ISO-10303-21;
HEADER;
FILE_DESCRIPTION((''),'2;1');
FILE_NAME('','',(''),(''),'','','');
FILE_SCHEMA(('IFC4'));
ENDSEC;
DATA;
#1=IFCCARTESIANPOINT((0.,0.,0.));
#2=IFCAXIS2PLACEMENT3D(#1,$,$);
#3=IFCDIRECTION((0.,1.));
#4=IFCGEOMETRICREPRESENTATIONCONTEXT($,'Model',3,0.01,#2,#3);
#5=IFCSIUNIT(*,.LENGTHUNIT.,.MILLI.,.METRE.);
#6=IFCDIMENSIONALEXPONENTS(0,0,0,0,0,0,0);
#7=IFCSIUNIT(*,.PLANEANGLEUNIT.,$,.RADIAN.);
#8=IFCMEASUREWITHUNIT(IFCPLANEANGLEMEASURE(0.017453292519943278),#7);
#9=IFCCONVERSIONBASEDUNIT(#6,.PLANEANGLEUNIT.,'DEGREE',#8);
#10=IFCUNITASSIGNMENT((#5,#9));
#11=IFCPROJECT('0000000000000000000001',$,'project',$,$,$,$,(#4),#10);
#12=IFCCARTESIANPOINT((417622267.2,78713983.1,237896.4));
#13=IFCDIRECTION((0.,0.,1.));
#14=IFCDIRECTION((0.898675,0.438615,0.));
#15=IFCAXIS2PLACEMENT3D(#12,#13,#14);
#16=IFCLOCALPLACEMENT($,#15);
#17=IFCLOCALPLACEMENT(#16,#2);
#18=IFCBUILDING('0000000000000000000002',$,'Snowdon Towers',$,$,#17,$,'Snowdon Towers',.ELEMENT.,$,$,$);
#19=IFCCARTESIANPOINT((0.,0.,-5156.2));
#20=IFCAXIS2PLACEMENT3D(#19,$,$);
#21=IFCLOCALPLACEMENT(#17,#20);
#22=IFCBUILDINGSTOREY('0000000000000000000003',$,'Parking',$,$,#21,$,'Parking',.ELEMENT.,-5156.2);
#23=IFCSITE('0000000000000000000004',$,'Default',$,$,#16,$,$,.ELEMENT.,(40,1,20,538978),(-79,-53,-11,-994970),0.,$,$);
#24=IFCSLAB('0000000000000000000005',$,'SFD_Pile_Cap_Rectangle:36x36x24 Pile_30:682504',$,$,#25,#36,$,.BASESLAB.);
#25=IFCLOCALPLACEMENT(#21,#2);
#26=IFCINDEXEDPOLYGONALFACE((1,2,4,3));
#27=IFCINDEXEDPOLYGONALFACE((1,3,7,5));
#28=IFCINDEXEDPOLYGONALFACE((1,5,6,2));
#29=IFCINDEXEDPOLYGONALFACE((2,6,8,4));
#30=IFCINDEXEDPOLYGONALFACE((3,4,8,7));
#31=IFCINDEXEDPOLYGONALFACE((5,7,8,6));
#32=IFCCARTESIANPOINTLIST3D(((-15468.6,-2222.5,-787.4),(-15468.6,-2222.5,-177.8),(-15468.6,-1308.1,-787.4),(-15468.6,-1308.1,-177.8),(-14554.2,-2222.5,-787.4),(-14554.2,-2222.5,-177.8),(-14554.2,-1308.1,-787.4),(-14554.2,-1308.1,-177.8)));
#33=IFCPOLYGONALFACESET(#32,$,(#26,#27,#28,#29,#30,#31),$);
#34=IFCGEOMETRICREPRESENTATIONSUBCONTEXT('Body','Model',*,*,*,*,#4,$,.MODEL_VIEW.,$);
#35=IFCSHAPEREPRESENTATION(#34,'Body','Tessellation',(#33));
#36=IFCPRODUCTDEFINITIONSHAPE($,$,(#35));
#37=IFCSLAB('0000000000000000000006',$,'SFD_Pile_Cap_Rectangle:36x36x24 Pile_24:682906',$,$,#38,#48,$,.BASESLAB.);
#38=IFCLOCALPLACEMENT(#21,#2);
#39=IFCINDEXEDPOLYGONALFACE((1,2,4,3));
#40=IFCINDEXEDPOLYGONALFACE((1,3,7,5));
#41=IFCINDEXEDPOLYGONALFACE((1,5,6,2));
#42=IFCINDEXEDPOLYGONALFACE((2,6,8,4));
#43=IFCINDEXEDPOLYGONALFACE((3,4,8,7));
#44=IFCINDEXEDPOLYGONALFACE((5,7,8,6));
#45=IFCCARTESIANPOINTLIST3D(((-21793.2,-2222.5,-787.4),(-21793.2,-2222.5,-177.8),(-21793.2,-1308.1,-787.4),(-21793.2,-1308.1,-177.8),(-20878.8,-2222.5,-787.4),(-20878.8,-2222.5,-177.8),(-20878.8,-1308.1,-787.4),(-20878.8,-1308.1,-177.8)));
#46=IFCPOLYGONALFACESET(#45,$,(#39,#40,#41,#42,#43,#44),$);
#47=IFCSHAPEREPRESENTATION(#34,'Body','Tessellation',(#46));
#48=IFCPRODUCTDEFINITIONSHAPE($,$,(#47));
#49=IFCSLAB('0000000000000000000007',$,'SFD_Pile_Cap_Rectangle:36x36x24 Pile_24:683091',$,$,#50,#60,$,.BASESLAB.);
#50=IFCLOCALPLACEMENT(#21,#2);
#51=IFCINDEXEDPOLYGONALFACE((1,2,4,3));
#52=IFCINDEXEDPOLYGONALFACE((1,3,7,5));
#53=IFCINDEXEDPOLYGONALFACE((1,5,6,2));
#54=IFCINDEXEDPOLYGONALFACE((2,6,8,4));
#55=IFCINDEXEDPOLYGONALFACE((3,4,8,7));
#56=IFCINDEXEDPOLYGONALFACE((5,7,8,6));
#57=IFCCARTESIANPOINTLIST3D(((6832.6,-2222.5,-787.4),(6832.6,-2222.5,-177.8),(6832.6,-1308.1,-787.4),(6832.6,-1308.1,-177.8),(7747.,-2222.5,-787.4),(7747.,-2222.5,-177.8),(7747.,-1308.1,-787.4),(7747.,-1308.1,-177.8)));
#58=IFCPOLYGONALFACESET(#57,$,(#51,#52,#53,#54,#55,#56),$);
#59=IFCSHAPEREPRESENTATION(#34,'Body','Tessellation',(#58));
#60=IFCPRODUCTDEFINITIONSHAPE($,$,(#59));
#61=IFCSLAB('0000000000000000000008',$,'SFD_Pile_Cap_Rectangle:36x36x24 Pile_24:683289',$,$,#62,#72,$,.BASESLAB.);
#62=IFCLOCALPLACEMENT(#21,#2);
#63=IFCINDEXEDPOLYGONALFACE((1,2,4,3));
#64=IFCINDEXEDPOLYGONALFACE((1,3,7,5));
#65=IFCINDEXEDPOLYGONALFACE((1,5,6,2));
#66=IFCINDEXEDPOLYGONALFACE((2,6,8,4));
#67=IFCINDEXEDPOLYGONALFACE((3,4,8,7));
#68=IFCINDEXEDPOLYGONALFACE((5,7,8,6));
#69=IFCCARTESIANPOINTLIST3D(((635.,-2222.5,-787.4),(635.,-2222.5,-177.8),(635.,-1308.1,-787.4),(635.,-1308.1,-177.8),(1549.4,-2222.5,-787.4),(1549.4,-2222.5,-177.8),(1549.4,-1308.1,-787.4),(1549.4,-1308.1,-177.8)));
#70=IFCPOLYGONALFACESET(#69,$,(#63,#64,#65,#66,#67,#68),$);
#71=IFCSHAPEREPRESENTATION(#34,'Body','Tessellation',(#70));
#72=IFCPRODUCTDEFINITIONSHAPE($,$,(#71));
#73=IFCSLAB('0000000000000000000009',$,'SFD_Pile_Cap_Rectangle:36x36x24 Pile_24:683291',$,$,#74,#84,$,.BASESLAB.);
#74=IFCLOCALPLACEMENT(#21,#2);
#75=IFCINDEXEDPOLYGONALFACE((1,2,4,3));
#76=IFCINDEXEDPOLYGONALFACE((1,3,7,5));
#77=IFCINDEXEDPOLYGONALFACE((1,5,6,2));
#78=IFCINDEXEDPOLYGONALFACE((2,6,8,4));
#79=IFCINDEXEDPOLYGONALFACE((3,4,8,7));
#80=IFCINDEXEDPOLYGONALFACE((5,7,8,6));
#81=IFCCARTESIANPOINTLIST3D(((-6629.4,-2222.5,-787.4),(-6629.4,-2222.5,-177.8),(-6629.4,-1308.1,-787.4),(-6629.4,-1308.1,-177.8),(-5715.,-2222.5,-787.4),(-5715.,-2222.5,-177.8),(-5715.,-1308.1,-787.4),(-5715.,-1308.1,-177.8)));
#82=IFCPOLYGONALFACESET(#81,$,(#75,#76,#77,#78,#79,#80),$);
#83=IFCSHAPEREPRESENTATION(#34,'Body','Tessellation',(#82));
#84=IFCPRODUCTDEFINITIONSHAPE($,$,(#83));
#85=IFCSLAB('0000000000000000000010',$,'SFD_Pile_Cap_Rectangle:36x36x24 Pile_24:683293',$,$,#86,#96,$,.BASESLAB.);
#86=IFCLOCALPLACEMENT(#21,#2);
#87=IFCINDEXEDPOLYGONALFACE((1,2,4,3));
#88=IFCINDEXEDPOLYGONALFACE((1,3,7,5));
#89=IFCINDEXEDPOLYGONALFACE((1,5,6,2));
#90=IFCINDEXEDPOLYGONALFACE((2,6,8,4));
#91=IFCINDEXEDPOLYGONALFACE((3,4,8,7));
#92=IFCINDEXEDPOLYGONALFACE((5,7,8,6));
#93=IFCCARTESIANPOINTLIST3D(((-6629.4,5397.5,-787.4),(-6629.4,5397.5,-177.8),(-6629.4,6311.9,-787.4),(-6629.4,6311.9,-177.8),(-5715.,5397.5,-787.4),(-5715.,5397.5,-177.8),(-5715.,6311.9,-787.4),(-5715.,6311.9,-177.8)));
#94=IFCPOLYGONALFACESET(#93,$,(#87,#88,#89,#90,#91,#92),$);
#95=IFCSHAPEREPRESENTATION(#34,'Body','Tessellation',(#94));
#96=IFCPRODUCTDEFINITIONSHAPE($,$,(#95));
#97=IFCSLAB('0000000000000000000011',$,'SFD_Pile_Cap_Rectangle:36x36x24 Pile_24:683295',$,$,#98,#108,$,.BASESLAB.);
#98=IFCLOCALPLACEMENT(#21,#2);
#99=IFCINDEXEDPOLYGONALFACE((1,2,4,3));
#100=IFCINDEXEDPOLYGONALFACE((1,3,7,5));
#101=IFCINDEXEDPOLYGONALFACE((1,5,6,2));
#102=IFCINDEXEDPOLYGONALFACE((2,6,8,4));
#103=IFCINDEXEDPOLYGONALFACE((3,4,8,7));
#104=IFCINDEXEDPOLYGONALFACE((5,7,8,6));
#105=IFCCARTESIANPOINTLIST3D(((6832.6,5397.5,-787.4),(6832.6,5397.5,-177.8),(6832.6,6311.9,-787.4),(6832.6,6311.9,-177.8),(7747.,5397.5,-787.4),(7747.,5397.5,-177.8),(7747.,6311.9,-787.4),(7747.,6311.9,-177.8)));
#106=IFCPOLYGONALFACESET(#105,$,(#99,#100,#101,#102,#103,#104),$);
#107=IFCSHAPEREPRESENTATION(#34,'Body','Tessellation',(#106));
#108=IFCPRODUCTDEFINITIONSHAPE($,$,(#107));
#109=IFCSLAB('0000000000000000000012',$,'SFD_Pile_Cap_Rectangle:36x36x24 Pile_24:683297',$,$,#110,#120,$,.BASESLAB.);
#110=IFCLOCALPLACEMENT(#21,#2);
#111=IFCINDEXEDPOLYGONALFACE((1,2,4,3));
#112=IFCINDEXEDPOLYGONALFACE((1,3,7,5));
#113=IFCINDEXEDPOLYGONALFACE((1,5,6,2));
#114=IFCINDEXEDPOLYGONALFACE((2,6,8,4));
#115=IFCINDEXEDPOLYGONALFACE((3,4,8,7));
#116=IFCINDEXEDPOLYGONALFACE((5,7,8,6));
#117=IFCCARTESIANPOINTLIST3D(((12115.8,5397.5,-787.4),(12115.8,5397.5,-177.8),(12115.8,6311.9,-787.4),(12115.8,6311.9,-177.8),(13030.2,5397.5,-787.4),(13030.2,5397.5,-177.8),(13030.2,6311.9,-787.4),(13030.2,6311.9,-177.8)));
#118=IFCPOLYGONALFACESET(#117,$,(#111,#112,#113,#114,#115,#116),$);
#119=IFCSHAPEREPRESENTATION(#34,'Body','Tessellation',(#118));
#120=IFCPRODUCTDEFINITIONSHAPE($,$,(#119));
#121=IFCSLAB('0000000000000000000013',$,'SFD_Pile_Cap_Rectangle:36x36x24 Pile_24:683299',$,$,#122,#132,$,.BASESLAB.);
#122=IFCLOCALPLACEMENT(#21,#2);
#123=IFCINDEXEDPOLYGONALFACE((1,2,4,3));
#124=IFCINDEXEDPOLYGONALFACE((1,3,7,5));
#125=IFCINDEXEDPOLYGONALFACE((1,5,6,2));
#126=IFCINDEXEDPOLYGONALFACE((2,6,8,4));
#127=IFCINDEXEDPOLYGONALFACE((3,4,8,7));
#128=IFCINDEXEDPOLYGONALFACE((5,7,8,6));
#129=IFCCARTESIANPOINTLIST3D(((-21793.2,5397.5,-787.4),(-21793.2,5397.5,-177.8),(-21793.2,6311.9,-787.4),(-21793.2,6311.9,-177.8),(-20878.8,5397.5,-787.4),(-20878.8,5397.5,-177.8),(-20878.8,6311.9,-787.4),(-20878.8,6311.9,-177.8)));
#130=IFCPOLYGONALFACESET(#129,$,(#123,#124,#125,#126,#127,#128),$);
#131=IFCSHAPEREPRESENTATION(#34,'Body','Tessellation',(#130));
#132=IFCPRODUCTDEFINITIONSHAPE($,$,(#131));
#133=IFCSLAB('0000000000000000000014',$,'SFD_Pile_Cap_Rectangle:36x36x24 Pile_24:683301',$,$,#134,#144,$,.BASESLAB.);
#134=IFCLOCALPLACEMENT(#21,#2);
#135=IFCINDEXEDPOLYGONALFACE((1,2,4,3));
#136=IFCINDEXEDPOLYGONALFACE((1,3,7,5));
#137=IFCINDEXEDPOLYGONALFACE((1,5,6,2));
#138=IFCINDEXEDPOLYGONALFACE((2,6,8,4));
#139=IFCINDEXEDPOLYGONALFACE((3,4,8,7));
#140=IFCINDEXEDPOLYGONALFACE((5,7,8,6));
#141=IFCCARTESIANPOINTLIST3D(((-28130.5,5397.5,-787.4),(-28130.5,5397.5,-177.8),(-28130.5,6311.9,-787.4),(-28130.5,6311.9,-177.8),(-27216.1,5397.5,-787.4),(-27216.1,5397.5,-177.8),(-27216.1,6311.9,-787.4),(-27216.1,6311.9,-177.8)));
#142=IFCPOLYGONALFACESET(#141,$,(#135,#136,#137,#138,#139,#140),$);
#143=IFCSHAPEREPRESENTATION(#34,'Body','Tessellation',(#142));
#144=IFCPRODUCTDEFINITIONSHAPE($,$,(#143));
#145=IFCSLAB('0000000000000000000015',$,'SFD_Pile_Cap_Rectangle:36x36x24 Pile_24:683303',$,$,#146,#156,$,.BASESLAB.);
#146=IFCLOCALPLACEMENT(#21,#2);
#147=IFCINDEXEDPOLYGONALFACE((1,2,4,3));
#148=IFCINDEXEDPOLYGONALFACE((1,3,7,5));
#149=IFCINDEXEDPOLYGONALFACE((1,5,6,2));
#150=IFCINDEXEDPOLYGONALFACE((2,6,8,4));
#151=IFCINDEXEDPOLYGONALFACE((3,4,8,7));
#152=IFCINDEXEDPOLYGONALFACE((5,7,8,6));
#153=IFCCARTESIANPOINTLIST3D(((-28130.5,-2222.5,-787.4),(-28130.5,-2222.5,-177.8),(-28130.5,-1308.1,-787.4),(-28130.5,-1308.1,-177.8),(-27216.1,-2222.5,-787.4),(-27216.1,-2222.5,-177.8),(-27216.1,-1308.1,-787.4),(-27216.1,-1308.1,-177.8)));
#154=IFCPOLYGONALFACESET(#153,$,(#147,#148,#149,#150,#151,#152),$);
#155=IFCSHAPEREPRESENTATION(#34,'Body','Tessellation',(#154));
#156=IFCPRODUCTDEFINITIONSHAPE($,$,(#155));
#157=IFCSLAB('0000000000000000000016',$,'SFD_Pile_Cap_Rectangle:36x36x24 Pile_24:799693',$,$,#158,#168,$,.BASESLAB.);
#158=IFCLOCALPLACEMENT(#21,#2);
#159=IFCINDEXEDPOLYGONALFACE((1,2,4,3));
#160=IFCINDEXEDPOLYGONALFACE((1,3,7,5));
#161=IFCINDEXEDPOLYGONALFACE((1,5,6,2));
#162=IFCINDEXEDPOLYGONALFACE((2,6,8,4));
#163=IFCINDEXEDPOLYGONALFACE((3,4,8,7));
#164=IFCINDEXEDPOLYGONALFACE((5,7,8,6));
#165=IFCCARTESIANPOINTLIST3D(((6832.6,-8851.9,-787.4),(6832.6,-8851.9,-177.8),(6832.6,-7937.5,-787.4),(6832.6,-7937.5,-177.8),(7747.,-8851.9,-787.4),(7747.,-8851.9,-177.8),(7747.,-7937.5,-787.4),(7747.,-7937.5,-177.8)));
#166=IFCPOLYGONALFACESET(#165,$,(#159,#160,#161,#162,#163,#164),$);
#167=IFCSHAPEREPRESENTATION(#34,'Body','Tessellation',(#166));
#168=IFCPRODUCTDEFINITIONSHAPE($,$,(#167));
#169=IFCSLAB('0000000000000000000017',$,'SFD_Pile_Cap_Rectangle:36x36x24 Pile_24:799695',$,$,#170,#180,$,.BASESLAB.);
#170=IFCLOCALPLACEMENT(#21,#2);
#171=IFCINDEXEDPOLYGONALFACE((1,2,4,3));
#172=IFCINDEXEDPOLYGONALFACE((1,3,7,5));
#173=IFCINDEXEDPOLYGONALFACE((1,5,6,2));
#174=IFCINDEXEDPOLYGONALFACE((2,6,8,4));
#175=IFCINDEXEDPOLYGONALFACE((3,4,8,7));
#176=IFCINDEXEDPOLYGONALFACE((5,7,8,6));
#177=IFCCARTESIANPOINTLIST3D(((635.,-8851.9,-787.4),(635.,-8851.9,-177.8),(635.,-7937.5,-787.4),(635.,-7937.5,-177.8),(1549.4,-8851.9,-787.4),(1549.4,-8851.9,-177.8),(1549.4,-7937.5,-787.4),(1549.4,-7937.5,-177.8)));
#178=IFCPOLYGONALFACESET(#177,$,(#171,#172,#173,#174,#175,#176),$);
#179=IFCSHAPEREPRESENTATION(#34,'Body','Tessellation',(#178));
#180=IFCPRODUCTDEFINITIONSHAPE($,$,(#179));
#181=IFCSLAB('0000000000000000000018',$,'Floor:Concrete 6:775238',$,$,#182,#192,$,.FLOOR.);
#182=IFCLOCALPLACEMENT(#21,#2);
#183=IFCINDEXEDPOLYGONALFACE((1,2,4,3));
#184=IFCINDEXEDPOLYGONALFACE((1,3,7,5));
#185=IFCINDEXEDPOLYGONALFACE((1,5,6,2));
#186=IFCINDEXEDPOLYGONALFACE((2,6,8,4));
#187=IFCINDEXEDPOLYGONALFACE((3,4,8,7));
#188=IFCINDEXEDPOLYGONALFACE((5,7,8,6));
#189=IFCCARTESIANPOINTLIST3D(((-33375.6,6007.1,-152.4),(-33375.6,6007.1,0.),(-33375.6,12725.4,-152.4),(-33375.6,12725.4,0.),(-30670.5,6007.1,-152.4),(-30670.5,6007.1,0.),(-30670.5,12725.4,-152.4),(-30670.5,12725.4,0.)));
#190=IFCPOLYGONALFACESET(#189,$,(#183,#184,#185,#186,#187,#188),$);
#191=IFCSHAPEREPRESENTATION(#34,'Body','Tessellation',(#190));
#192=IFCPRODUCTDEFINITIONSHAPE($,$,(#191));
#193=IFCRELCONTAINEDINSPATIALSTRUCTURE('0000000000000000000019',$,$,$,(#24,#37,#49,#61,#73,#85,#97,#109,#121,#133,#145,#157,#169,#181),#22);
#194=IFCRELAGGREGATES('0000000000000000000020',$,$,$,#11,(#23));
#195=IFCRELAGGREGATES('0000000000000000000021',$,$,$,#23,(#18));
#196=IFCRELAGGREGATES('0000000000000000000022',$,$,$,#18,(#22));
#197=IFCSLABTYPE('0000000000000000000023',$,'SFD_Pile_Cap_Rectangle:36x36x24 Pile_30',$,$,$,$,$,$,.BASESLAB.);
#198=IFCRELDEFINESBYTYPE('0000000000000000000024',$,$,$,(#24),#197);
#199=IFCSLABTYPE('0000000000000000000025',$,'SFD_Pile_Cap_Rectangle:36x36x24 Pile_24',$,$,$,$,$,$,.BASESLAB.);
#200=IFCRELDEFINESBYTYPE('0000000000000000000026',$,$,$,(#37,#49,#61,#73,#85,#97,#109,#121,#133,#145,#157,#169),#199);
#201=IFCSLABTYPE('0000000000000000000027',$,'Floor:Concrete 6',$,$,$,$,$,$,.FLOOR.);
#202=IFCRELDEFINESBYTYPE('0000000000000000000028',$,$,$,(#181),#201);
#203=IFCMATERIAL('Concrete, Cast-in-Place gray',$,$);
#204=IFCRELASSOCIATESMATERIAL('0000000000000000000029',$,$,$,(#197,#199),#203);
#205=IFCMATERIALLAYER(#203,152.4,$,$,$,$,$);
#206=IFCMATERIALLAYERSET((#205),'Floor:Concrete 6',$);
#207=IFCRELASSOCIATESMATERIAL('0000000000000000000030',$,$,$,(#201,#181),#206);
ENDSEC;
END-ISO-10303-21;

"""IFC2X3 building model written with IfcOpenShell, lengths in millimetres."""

from ifc_helpers import new_model, entity, si_unit, converted_unit, direction, frame, frame_2d, origin, origin_2d_with_axis, place, context, subcontext, project, spatial, rectangle, extrude, material, layer, layer_set, layer_usage, type_object, element, save


model = new_model("IFC2X3")

# Units and contexts
model_context = context("Model", 3, precision=0.01, world=origin(), true_north=direction((0.0, 1.0)))
body_context = subcontext(model_context, "Body", "Model", "MODEL_VIEW")
ifc_project = project(units=[si_unit("LENGTHUNIT", "METRE", prefix="MILLI"), converted_unit("PLANEANGLEUNIT", "DEGREE", entity("IfcPlaneAngleMeasure", 0.017453292519943278), si_unit("PLANEANGLEUNIT", "RADIAN"), dimensions=[0, 0, 0, 0, 0, 0, 0])], contexts=[model_context])

# Site, building, storey
site_placement = place(None, frame((417622267.2, 78713983.1, 237896.4), z_axis=(0.0, 0.0, 1.0), x_axis=(0.898675, 0.438615, 0.0)))
site = spatial("IfcSite", under=ifc_project, at=site_placement, Name="Default", CompositionType="ELEMENT", RefLatitude=(40, 1, 20, 538978), RefLongitude=(-79, -53, -11, -994970), RefElevation=0.0)
building_placement = place(site_placement, origin())
building = spatial("IfcBuilding", under=site, at=building_placement, Name="Snowdon Towers", LongName="Snowdon Towers", CompositionType="ELEMENT")
storey_placement = place(building_placement, frame((0.0, 0.0, -5156.2)))
storey = spatial("IfcBuildingStorey", under=building, at=storey_placement, Name="Parking", LongName="Parking", CompositionType="ELEMENT", Elevation=-5156.2)

# Slabs
ifc_material = material(Name="Concrete, Cast-in-Place gray")
slab_type_1 = type_object("IfcSlabType", Name="SFD_Pile_Cap_Rectangle:36x36x24 Pile_30", PredefinedType="BASESLAB", material=ifc_material)
slab_1_placement = place(storey_placement, frame((0.0, 0.0, -177.8)))
element("IfcSlab", 1, at=slab_1_placement, inside=storey, type_object=slab_type_1, Name="SFD_Pile_Cap_Rectangle:36x36x24 Pile_30:682504", PredefinedType="BASESLAB", context=body_context, shape_type="SweptSolid", body=[
    extrude(rectangle(XDim=914.4, YDim=914.4, at=origin_2d_with_axis()), frame((-15011.4, -1765.3, -609.6), z_axis=(0.0, 0.0, 1.0), x_axis=(-1.0, 0.0, 0.0)), (0.0, 0.0, 1.0), 609.6),
])
slab_type_2 = type_object("IfcSlabType", Name="SFD_Pile_Cap_Rectangle:36x36x24 Pile_24", PredefinedType="BASESLAB", material=ifc_material)
slab_2_placement = place(storey_placement, frame((0.0, 0.0, -177.8)))
element("IfcSlab", 2, at=slab_2_placement, inside=storey, type_object=slab_type_2, Name="SFD_Pile_Cap_Rectangle:36x36x24 Pile_24:682906", PredefinedType="BASESLAB", context=body_context, shape_type="SweptSolid", body=[
    extrude(rectangle(XDim=914.4, YDim=914.4, at=frame_2d((0.0, 0.0), x_axis=(1.0, 0.0))), frame((-21336.0, -1765.3, -609.6), z_axis=(0.0, 0.0, 1.0), x_axis=(-1.0, 0.0, 0.0)), (0.0, 0.0, 1.0), 609.6),
])
slab_3_placement = place(storey_placement, frame((0.0, 0.0, -177.8)))
element("IfcSlab", 3, at=slab_3_placement, inside=storey, type_object=slab_type_2, Name="SFD_Pile_Cap_Rectangle:36x36x24 Pile_24:683091", PredefinedType="BASESLAB", context=body_context, shape_type="SweptSolid", body=[
    extrude(rectangle(XDim=914.4, YDim=914.4, at=origin_2d_with_axis()), frame((7289.8, -1765.3, -609.6), z_axis=(0.0, 0.0, 1.0), x_axis=(-1.0, 0.0, 0.0)), (0.0, 0.0, 1.0), 609.6),
])
slab_4_placement = place(storey_placement, frame((0.0, 0.0, -177.8)))
element("IfcSlab", 4, at=slab_4_placement, inside=storey, type_object=slab_type_2, Name="SFD_Pile_Cap_Rectangle:36x36x24 Pile_24:683289", PredefinedType="BASESLAB", context=body_context, shape_type="SweptSolid", body=[
    extrude(rectangle(XDim=914.4, YDim=914.4, at=origin_2d_with_axis()), frame((1092.2, -1765.3, -609.6), z_axis=(0.0, 0.0, 1.0), x_axis=(-1.0, 0.0, 0.0)), (0.0, 0.0, 1.0), 609.6),
])
slab_5_placement = place(storey_placement, frame((0.0, 0.0, -177.8)))
element("IfcSlab", 5, at=slab_5_placement, inside=storey, type_object=slab_type_2, Name="SFD_Pile_Cap_Rectangle:36x36x24 Pile_24:683291", PredefinedType="BASESLAB", context=body_context, shape_type="SweptSolid", body=[
    extrude(rectangle(XDim=914.4, YDim=914.4, at=origin_2d_with_axis()), frame((-6172.2, -1765.3, -609.6), z_axis=(0.0, 0.0, 1.0), x_axis=(-1.0, 0.0, 0.0)), (0.0, 0.0, 1.0), 609.6),
])
slab_6_placement = place(storey_placement, frame((0.0, 0.0, -177.8)))
element("IfcSlab", 6, at=slab_6_placement, inside=storey, type_object=slab_type_2, Name="SFD_Pile_Cap_Rectangle:36x36x24 Pile_24:683293", PredefinedType="BASESLAB", context=body_context, shape_type="SweptSolid", body=[
    extrude(rectangle(XDim=914.4, YDim=914.4, at=frame_2d((0.0, 0.0), x_axis=(1.0, 0.0))), frame((-6172.2, 5854.7, -609.6), z_axis=(0.0, 0.0, 1.0), x_axis=(-1.0, 0.0, 0.0)), (0.0, 0.0, 1.0), 609.6),
])
slab_7_placement = place(storey_placement, frame((0.0, 0.0, -177.8)))
element("IfcSlab", 7, at=slab_7_placement, inside=storey, type_object=slab_type_2, Name="SFD_Pile_Cap_Rectangle:36x36x24 Pile_24:683295", PredefinedType="BASESLAB", context=body_context, shape_type="SweptSolid", body=[
    extrude(rectangle(XDim=914.4, YDim=914.4, at=frame_2d((0.0, 0.0), x_axis=(1.0, 0.0))), frame((7289.8, 5854.7, -609.6), z_axis=(0.0, 0.0, 1.0), x_axis=(-1.0, 0.0, 0.0)), (0.0, 0.0, 1.0), 609.6),
])
slab_8_placement = place(storey_placement, frame((0.0, 0.0, -177.8)))
element("IfcSlab", 8, at=slab_8_placement, inside=storey, type_object=slab_type_2, Name="SFD_Pile_Cap_Rectangle:36x36x24 Pile_24:683297", PredefinedType="BASESLAB", context=body_context, shape_type="SweptSolid", body=[
    extrude(rectangle(XDim=914.4, YDim=914.4, at=frame_2d((0.0, 0.0), x_axis=(1.0, 0.0))), frame((12573.0, 5854.7, -609.6), z_axis=(0.0, 0.0, 1.0), x_axis=(-1.0, 0.0, 0.0)), (0.0, 0.0, 1.0), 609.6),
])
slab_9_placement = place(storey_placement, frame((0.0, 0.0, -177.8)))
element("IfcSlab", 9, at=slab_9_placement, inside=storey, type_object=slab_type_2, Name="SFD_Pile_Cap_Rectangle:36x36x24 Pile_24:683299", PredefinedType="BASESLAB", context=body_context, shape_type="SweptSolid", body=[
    extrude(rectangle(XDim=914.4, YDim=914.4, at=frame_2d((0.0, 0.0), x_axis=(1.0, 0.0))), frame((-21336.0, 5854.7, -609.6), z_axis=(0.0, 0.0, 1.0), x_axis=(-1.0, 0.0, 0.0)), (0.0, 0.0, 1.0), 609.6),
])
slab_10_placement = place(storey_placement, frame((0.0, 0.0, -177.8)))
element("IfcSlab", 10, at=slab_10_placement, inside=storey, type_object=slab_type_2, Name="SFD_Pile_Cap_Rectangle:36x36x24 Pile_24:683301", PredefinedType="BASESLAB", context=body_context, shape_type="SweptSolid", body=[
    extrude(rectangle(XDim=914.4, YDim=914.4, at=frame_2d((0.0, 0.0), x_axis=(1.0, 0.0))), frame((-27673.3, 5854.7, -609.6), z_axis=(0.0, 0.0, 1.0), x_axis=(-1.0, 0.0, 0.0)), (0.0, 0.0, 1.0), 609.6),
])
slab_11_placement = place(storey_placement, frame((0.0, 0.0, -177.8)))
element("IfcSlab", 11, at=slab_11_placement, inside=storey, type_object=slab_type_2, Name="SFD_Pile_Cap_Rectangle:36x36x24 Pile_24:683303", PredefinedType="BASESLAB", context=body_context, shape_type="SweptSolid", body=[
    extrude(rectangle(XDim=914.4, YDim=914.4, at=frame_2d((0.0, 0.0), x_axis=(1.0, 0.0))), frame((-27673.3, -1765.3, -609.6), z_axis=(0.0, 0.0, 1.0), x_axis=(-1.0, 0.0, 0.0)), (0.0, 0.0, 1.0), 609.6),
])
slab_12_placement = place(storey_placement, frame((0.0, 0.0, -177.8)))
element("IfcSlab", 12, at=slab_12_placement, inside=storey, type_object=slab_type_2, Name="SFD_Pile_Cap_Rectangle:36x36x24 Pile_24:799693", PredefinedType="BASESLAB", context=body_context, shape_type="SweptSolid", body=[
    extrude(rectangle(XDim=914.4, YDim=914.4, at=origin_2d_with_axis()), frame((7289.8, -8394.7, -609.6), z_axis=(0.0, 0.0, 1.0), x_axis=(-1.0, 0.0, 0.0)), (0.0, 0.0, 1.0), 609.6),
])
slab_13_placement = place(storey_placement, frame((0.0, 0.0, -177.8)))
element("IfcSlab", 13, at=slab_13_placement, inside=storey, type_object=slab_type_2, Name="SFD_Pile_Cap_Rectangle:36x36x24 Pile_24:799695", PredefinedType="BASESLAB", context=body_context, shape_type="SweptSolid", body=[
    extrude(rectangle(XDim=914.4, YDim=914.4, at=frame_2d((0.0, 0.0), x_axis=(1.0, 0.0))), frame((1092.2, -8394.7, -609.6), z_axis=(0.0, 0.0, 1.0), x_axis=(-1.0, 0.0, 0.0)), (0.0, 0.0, 1.0), 609.6),
])

# Shared definitions
ifc_layer = layer(ifc_material, 152.4)
ifc_layer_set = layer_set([ifc_layer], Name="Floor:Concrete 6")
slab_type_3 = type_object("IfcSlabType", Name="Floor:Concrete 6", PredefinedType="FLOOR", material=ifc_layer_set)

# Slab
ifc_layer_usage_1 = layer_usage(ifc_layer_set, "AXIS3", "POSITIVE", 0.0)
slab_14_placement = place(storey_placement, origin())
element("IfcSlab", 14, at=slab_14_placement, inside=storey, type_object=slab_type_3, material=ifc_layer_usage_1, Name="Floor:Concrete 6:775238", PredefinedType="FLOOR", context=body_context, shape_type="SweptSolid", body=[
    extrude(rectangle(XDim=6718.3, YDim=2705.1, at=frame_2d((0.0, 0.0), x_axis=(1.0, 0.0))), frame((-32023.0, 9366.3, 0.0), z_axis=(0.0, 0.0, -1.0), x_axis=(0.0, 1.0, 0.0)), (0.0, 0.0, 1.0), 152.4),
])

save(model, "model.ifc")
